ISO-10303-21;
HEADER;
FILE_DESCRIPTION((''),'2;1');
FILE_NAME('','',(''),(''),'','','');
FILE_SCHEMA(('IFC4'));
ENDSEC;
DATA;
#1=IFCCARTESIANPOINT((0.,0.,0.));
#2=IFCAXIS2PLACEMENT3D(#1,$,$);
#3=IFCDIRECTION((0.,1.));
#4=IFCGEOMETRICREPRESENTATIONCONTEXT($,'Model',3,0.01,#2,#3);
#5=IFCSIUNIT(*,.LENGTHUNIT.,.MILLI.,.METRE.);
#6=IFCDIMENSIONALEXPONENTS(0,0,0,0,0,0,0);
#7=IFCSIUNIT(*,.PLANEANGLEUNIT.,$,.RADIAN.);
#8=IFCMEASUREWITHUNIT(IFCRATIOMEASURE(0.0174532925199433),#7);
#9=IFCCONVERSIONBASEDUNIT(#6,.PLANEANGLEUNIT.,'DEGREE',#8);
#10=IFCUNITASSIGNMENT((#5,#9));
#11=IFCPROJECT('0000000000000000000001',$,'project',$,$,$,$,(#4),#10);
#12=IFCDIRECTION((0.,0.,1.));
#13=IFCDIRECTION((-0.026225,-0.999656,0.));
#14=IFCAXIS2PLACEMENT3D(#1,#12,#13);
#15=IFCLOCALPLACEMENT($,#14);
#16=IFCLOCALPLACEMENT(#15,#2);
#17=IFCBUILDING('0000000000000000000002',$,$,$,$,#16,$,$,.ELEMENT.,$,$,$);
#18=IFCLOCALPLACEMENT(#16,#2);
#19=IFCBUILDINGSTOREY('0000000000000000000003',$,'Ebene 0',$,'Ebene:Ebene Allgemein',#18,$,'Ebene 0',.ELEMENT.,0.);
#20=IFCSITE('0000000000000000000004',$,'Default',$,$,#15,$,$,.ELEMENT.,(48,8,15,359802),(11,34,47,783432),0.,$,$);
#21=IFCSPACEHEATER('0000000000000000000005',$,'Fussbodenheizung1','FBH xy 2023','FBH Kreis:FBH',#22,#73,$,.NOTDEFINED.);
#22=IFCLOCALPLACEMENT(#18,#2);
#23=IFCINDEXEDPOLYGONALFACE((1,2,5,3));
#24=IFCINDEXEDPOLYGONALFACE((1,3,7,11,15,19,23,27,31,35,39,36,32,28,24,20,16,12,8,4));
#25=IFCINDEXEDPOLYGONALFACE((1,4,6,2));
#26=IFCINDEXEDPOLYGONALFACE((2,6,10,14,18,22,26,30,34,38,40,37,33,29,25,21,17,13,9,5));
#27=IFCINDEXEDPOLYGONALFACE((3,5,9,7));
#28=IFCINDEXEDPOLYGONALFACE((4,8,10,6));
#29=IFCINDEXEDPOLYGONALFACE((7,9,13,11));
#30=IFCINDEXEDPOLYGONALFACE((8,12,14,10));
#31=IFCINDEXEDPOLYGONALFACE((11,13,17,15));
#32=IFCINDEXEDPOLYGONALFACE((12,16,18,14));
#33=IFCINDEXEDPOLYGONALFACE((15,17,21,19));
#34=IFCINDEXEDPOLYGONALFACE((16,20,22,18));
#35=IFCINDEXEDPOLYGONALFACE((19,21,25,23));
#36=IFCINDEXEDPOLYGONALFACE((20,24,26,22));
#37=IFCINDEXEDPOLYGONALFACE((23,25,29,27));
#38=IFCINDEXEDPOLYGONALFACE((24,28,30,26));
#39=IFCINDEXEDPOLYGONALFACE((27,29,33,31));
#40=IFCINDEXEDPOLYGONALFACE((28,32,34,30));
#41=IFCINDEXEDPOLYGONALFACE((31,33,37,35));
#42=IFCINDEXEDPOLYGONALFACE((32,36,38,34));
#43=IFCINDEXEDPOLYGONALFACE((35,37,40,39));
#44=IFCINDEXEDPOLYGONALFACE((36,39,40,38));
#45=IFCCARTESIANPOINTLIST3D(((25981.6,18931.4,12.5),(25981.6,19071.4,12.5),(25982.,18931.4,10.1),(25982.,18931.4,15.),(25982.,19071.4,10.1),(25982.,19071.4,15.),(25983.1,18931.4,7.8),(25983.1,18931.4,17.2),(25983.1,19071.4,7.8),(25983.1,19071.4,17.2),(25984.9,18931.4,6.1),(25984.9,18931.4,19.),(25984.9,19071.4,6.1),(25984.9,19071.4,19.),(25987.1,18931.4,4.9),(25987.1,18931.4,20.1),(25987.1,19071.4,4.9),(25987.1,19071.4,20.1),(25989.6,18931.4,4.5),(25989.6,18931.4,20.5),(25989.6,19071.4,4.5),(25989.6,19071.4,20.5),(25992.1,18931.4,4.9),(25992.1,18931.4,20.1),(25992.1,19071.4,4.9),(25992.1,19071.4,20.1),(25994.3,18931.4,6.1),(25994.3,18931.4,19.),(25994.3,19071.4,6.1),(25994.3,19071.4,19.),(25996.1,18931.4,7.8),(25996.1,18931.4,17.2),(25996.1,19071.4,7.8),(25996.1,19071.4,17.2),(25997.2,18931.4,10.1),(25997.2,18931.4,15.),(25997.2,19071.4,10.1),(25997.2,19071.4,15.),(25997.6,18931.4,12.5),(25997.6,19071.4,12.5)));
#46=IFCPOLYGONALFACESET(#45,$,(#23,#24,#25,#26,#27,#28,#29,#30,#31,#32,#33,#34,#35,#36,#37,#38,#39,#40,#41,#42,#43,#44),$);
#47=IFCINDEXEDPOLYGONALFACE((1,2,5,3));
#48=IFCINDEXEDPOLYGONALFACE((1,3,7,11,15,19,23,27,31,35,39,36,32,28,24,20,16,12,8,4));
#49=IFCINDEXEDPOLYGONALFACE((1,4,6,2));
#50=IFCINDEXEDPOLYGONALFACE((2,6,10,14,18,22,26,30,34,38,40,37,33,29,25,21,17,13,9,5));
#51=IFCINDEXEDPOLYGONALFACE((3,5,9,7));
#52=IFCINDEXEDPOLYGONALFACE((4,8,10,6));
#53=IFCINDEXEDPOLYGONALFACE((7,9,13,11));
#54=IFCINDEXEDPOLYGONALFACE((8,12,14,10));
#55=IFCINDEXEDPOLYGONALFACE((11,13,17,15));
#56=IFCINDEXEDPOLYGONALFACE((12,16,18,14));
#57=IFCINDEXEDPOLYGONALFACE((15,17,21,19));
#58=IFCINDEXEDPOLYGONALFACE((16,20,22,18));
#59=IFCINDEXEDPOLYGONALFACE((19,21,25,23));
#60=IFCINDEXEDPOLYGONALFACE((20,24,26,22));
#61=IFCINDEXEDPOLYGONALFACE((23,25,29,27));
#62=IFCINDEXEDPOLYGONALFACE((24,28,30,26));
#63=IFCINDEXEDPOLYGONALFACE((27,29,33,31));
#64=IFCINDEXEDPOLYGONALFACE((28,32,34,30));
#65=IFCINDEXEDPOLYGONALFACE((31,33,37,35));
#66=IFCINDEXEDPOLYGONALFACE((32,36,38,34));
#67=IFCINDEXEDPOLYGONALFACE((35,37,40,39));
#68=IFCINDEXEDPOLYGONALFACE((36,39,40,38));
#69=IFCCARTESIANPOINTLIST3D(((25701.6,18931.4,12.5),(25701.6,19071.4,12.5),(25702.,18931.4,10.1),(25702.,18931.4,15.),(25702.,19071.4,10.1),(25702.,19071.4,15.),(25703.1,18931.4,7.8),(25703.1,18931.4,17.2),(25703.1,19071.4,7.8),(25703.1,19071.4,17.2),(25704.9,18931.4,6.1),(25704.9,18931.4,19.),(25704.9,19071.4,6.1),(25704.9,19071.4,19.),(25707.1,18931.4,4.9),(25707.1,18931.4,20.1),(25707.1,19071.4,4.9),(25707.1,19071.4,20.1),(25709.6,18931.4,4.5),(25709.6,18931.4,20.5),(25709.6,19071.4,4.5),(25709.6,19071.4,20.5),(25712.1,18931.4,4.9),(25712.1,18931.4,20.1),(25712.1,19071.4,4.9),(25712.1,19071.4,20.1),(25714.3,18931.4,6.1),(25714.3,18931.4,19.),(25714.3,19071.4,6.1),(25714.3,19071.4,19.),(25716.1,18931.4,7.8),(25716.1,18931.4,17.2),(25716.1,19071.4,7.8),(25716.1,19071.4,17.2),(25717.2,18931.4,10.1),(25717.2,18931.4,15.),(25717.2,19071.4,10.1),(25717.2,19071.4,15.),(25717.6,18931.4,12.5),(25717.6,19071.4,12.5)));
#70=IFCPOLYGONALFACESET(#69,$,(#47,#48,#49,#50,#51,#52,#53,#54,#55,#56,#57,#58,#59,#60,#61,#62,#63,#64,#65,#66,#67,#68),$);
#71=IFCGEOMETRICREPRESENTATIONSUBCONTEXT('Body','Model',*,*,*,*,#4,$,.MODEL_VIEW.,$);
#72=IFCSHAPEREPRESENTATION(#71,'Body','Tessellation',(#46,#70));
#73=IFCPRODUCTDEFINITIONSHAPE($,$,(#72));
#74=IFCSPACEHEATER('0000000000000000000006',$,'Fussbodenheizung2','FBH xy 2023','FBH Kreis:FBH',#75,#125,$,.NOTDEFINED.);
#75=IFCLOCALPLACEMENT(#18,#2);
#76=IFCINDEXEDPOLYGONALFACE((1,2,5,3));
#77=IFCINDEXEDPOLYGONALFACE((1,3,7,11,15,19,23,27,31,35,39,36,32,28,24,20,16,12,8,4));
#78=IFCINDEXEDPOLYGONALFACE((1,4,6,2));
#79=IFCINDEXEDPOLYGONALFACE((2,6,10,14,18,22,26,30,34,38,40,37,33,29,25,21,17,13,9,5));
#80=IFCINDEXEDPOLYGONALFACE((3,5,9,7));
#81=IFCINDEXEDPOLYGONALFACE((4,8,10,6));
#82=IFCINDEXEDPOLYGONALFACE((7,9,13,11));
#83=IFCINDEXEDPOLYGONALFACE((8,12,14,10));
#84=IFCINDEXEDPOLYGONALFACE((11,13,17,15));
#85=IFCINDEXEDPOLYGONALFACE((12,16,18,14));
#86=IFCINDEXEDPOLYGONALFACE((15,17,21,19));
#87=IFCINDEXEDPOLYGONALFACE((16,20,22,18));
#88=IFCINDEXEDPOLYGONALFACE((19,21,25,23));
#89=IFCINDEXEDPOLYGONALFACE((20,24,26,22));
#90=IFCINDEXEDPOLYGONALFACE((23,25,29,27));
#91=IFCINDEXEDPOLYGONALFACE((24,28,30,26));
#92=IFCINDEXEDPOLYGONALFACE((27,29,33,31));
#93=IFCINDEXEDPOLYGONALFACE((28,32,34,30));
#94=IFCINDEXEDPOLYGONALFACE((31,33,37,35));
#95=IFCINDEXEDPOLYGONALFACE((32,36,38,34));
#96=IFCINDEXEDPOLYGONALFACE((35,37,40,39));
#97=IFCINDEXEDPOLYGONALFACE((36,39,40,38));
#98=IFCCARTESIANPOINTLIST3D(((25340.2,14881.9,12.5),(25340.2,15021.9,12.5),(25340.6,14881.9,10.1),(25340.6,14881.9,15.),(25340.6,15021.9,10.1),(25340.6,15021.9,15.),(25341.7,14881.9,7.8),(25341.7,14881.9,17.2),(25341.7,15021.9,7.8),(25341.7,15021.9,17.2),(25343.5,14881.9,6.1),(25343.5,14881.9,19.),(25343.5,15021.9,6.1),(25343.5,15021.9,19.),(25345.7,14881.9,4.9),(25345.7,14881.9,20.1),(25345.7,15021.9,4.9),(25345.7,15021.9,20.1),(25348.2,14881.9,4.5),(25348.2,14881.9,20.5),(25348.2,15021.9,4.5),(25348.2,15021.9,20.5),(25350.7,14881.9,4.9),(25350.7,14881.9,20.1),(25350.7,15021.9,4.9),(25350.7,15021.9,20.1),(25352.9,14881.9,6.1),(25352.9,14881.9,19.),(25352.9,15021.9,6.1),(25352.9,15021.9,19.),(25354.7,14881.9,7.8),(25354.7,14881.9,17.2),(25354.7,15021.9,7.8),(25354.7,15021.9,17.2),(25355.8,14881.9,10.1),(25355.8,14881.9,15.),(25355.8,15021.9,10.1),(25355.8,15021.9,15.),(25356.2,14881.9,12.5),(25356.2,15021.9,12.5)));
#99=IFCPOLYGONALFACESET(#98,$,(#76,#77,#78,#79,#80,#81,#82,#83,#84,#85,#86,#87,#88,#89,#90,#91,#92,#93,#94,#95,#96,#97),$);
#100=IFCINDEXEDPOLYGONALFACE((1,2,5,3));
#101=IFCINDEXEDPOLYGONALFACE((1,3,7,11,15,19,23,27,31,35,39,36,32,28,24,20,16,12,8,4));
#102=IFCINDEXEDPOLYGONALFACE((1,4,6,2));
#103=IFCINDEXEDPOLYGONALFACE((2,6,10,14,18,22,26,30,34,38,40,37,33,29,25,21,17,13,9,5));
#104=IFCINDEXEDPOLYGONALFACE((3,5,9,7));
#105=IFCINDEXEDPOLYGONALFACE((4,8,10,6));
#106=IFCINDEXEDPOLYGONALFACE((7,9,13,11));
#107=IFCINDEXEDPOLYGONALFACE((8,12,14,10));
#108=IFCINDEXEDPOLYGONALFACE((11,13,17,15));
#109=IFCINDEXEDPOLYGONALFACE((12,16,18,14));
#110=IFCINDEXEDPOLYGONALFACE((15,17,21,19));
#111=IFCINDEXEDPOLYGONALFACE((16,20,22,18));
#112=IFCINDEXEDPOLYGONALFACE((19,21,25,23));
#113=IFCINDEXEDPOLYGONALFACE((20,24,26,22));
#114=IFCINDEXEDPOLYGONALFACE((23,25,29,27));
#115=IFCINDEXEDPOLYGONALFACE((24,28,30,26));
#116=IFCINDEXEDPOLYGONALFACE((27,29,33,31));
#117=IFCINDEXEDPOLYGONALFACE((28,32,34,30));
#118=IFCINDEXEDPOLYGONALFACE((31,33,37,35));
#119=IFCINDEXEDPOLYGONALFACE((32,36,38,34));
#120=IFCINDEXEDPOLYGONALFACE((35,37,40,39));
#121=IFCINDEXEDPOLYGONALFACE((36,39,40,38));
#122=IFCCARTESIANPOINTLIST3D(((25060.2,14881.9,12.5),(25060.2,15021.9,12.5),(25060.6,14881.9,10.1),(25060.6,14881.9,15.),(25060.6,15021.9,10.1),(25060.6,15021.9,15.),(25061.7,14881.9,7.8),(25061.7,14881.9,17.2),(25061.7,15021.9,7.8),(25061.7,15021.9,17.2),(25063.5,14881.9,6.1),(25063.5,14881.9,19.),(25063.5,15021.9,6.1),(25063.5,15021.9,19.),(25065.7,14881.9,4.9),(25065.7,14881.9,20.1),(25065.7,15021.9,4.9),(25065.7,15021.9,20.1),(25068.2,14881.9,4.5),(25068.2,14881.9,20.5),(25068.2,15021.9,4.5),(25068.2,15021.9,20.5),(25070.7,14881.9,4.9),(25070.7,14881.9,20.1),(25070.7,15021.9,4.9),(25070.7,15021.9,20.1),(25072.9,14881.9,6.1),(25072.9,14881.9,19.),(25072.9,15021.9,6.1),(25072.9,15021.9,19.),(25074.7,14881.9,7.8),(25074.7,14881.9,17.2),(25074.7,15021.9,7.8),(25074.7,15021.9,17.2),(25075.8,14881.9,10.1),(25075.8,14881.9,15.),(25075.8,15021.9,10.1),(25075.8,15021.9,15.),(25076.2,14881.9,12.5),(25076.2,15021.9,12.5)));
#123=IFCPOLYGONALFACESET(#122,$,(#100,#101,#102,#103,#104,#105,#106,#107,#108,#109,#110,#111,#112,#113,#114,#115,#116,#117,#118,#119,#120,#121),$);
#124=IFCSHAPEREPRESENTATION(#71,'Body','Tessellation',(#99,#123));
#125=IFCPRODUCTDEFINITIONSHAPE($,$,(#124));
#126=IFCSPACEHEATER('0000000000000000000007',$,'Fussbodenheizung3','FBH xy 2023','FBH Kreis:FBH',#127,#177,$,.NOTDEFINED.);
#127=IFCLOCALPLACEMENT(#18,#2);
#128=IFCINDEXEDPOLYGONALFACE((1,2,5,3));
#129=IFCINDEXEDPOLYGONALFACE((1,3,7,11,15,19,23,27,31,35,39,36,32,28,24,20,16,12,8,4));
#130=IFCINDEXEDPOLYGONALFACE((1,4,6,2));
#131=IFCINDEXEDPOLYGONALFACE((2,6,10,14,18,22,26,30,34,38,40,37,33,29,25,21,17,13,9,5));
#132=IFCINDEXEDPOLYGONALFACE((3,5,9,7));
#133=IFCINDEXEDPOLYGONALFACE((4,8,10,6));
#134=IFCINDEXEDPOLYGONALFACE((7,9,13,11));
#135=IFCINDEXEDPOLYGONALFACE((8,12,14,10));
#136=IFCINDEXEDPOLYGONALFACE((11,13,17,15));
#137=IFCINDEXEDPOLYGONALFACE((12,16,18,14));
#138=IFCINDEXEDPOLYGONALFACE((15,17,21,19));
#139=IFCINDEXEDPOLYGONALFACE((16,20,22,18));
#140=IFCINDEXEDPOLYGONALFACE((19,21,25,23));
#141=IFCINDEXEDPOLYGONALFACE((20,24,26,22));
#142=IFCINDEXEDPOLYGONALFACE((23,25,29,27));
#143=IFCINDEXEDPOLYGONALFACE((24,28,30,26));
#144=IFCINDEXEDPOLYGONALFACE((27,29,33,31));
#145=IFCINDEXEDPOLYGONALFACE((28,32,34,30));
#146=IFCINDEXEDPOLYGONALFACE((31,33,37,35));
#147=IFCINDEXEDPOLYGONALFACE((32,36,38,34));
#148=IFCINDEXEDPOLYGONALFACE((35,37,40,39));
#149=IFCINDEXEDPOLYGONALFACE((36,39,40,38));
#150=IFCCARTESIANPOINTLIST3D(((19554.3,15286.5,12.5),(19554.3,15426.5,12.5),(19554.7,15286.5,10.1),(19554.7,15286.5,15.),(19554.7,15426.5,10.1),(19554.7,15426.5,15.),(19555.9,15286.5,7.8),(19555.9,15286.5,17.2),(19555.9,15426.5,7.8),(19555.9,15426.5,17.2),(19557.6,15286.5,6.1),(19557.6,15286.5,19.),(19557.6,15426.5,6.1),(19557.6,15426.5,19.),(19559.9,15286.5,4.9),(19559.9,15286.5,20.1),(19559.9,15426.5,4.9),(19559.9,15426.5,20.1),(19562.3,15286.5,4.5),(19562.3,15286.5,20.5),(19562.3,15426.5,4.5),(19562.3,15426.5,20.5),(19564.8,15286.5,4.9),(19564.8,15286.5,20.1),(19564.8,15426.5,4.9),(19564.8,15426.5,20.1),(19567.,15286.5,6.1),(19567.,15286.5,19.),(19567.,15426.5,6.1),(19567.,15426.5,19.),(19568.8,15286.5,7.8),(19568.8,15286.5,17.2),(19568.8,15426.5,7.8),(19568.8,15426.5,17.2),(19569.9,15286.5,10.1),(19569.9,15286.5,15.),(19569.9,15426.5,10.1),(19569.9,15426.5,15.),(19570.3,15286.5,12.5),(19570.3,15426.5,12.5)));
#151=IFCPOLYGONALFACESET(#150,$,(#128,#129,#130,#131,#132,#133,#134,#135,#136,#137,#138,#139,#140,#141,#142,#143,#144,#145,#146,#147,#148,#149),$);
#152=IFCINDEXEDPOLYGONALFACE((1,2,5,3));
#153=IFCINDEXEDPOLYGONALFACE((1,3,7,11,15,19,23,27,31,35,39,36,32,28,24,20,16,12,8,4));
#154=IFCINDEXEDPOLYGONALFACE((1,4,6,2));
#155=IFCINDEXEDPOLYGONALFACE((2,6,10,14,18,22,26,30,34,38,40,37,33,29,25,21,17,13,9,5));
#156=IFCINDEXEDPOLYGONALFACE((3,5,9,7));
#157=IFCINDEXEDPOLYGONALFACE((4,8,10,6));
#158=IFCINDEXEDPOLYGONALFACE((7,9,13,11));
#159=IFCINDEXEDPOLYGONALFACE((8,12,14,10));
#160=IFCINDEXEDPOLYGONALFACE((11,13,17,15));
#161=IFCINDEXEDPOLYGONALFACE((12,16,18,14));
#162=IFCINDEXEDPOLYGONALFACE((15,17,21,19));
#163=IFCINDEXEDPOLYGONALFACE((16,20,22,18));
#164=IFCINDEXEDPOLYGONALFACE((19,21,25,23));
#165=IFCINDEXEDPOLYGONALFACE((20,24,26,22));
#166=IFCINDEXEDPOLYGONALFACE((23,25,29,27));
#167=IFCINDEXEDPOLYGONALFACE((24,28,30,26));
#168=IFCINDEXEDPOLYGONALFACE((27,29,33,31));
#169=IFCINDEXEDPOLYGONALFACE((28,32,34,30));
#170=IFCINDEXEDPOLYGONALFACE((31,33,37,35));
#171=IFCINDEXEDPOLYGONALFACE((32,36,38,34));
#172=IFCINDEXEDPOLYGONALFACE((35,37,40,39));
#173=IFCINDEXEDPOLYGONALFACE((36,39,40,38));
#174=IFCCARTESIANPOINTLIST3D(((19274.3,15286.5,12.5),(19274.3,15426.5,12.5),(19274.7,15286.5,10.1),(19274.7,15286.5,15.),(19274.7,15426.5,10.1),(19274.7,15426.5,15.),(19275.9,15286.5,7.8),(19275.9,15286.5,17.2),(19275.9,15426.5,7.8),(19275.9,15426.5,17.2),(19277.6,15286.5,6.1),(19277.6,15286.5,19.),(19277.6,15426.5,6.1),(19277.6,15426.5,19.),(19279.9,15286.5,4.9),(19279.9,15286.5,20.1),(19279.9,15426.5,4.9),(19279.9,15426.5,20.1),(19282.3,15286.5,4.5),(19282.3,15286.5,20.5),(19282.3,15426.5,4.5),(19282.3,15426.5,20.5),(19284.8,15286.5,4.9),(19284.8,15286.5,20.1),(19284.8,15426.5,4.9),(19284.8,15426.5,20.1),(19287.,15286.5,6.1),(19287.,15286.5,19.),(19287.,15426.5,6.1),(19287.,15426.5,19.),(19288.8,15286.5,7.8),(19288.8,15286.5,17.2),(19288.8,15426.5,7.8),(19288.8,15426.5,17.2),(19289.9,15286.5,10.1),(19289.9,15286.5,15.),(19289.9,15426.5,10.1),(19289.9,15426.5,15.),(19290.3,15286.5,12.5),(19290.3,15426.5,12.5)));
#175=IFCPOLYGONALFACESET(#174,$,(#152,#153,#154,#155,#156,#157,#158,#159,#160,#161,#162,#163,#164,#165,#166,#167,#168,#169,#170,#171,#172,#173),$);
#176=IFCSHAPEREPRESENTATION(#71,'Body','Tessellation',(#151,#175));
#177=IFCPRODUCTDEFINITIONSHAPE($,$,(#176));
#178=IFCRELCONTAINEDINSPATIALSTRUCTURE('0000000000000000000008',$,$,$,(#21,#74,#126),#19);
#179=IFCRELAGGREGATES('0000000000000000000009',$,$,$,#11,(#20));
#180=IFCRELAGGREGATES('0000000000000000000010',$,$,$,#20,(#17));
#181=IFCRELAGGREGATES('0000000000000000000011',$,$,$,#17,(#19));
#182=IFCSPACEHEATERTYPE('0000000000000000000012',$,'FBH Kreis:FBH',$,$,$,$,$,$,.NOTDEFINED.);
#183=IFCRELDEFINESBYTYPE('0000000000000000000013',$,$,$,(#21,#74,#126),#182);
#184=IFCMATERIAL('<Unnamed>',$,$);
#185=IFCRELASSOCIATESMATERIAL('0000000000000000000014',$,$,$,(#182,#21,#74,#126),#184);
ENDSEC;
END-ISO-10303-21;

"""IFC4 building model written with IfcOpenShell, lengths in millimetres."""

from ifc_helpers import new_model, entity, si_unit, converted_unit, direction, frame, origin, place, context, subcontext, project, spatial, indexed_curve, outline, extrude, source, transform, mapped, material, type_object, type_shapes, element, save


model = new_model("IFC4")

# Units and contexts
model_context = context("Model", 3, precision=0.01, world=origin(), true_north=direction((0.0, 1.0)))
body_context = subcontext(model_context, "Body", "Model", "MODEL_VIEW")
ifc_project = project(units=[si_unit("LENGTHUNIT", "METRE", prefix="MILLI"), converted_unit("PLANEANGLEUNIT", "DEGREE", entity("IfcRatioMeasure", 0.0174532925199433), si_unit("PLANEANGLEUNIT", "RADIAN"), dimensions=[0, 0, 0, 0, 0, 0, 0])], contexts=[model_context])

# Site, building, storey
site_placement = place(None, frame((0.0, 0.0, 0.0), z_axis=(0.0, 0.0, 1.0), x_axis=(-0.026225, -0.999656, 0.0)))
site = spatial("IfcSite", under=ifc_project, at=site_placement, Name="Default", CompositionType="ELEMENT", RefLatitude=(48, 8, 15, 359802), RefLongitude=(11, 34, 47, 783432), RefElevation=0.0)
building_placement = place(site_placement, origin())
building = spatial("IfcBuilding", under=site, at=building_placement, CompositionType="ELEMENT")
storey_placement = place(building_placement, origin())
storey = spatial("IfcBuildingStorey", under=building, at=storey_placement, Name="Ebene 0", ObjectType="Ebene:Ebene Allgemein", LongName="Ebene 0", CompositionType="ELEMENT", Elevation=0.0)

# Space heaters
ifc_material = material(Name="<Unnamed>")
space_heater_type = type_object("IfcSpaceHeaterType", Name="FBH Kreis:FBH", PredefinedType="NOTDEFINED", material=ifc_material)
shared_shape = source(origin(), body_context, "Body", "SweptSolid", [
    extrude(outline(indexed_curve([(8.0, 0.0), (7.6, 2.5), (6.5, 4.7), (4.7, 6.5), (2.5, 7.6), (0.0, 8.0), (-2.5, 7.6), (-4.7, 6.5), (-6.5, 4.7), (-7.6, 2.5), (-8.0, 0.0), (-7.6, -2.5), (-6.5, -4.7), (-4.7, -6.5), (-2.5, -7.6), (0.0, -8.0), (2.5, -7.6), (4.7, -6.5), (6.5, -4.7), (7.6, -2.5), (8.0, 0.0)], self_intersect=False)), frame((140.0, -1621.8, -83.0), z_axis=(0.0, 1.0, 0.0), x_axis=(1.0, 0.0, 0.0)), (0.0, 0.0, 1.0), 140.0),
    extrude(outline(indexed_curve([(8.0, 0.0), (7.6, 2.5), (6.5, 4.7), (4.7, 6.5), (2.5, 7.6), (0.0, 8.0), (-2.5, 7.6), (-4.7, 6.5), (-6.5, 4.7), (-7.6, 2.5), (-8.0, 0.0), (-7.6, -2.5), (-6.5, -4.7), (-4.7, -6.5), (-2.5, -7.6), (0.0, -8.0), (2.5, -7.6), (4.7, -6.5), (6.5, -4.7), (7.6, -2.5), (8.0, 0.0)], self_intersect=False)), frame((-140.0, -1621.8, -83.0), z_axis=(0.0, 1.0, 0.0), x_axis=(1.0, 0.0, 0.0)), (0.0, 0.0, 1.0), 140.0),
])
type_shapes(space_heater_type, [shared_shape])
for number, where, name in (
    (1, (25849.6, 20553.2, 95.5), "Fussbodenheizung1"),
    (2, (25208.2, 16503.6, 95.5), "Fussbodenheizung2"),
    (3, (19422.3, 16908.2, 95.5), "Fussbodenheizung3"),
):
    element("IfcSpaceHeater", number, at=place(storey_placement, frame(where)), inside=storey, type_object=space_heater_type, material=ifc_material, Name=name, Description="FBH xy 2023", ObjectType="FBH Kreis:FBH", PredefinedType="NOTDEFINED", context=body_context, shape_type="MappedRepresentation", body=[
        mapped(shared_shape, transform((0.0, 0.0, 0.0), scale=1.0)),
    ])

save(model, "model.ifc")
